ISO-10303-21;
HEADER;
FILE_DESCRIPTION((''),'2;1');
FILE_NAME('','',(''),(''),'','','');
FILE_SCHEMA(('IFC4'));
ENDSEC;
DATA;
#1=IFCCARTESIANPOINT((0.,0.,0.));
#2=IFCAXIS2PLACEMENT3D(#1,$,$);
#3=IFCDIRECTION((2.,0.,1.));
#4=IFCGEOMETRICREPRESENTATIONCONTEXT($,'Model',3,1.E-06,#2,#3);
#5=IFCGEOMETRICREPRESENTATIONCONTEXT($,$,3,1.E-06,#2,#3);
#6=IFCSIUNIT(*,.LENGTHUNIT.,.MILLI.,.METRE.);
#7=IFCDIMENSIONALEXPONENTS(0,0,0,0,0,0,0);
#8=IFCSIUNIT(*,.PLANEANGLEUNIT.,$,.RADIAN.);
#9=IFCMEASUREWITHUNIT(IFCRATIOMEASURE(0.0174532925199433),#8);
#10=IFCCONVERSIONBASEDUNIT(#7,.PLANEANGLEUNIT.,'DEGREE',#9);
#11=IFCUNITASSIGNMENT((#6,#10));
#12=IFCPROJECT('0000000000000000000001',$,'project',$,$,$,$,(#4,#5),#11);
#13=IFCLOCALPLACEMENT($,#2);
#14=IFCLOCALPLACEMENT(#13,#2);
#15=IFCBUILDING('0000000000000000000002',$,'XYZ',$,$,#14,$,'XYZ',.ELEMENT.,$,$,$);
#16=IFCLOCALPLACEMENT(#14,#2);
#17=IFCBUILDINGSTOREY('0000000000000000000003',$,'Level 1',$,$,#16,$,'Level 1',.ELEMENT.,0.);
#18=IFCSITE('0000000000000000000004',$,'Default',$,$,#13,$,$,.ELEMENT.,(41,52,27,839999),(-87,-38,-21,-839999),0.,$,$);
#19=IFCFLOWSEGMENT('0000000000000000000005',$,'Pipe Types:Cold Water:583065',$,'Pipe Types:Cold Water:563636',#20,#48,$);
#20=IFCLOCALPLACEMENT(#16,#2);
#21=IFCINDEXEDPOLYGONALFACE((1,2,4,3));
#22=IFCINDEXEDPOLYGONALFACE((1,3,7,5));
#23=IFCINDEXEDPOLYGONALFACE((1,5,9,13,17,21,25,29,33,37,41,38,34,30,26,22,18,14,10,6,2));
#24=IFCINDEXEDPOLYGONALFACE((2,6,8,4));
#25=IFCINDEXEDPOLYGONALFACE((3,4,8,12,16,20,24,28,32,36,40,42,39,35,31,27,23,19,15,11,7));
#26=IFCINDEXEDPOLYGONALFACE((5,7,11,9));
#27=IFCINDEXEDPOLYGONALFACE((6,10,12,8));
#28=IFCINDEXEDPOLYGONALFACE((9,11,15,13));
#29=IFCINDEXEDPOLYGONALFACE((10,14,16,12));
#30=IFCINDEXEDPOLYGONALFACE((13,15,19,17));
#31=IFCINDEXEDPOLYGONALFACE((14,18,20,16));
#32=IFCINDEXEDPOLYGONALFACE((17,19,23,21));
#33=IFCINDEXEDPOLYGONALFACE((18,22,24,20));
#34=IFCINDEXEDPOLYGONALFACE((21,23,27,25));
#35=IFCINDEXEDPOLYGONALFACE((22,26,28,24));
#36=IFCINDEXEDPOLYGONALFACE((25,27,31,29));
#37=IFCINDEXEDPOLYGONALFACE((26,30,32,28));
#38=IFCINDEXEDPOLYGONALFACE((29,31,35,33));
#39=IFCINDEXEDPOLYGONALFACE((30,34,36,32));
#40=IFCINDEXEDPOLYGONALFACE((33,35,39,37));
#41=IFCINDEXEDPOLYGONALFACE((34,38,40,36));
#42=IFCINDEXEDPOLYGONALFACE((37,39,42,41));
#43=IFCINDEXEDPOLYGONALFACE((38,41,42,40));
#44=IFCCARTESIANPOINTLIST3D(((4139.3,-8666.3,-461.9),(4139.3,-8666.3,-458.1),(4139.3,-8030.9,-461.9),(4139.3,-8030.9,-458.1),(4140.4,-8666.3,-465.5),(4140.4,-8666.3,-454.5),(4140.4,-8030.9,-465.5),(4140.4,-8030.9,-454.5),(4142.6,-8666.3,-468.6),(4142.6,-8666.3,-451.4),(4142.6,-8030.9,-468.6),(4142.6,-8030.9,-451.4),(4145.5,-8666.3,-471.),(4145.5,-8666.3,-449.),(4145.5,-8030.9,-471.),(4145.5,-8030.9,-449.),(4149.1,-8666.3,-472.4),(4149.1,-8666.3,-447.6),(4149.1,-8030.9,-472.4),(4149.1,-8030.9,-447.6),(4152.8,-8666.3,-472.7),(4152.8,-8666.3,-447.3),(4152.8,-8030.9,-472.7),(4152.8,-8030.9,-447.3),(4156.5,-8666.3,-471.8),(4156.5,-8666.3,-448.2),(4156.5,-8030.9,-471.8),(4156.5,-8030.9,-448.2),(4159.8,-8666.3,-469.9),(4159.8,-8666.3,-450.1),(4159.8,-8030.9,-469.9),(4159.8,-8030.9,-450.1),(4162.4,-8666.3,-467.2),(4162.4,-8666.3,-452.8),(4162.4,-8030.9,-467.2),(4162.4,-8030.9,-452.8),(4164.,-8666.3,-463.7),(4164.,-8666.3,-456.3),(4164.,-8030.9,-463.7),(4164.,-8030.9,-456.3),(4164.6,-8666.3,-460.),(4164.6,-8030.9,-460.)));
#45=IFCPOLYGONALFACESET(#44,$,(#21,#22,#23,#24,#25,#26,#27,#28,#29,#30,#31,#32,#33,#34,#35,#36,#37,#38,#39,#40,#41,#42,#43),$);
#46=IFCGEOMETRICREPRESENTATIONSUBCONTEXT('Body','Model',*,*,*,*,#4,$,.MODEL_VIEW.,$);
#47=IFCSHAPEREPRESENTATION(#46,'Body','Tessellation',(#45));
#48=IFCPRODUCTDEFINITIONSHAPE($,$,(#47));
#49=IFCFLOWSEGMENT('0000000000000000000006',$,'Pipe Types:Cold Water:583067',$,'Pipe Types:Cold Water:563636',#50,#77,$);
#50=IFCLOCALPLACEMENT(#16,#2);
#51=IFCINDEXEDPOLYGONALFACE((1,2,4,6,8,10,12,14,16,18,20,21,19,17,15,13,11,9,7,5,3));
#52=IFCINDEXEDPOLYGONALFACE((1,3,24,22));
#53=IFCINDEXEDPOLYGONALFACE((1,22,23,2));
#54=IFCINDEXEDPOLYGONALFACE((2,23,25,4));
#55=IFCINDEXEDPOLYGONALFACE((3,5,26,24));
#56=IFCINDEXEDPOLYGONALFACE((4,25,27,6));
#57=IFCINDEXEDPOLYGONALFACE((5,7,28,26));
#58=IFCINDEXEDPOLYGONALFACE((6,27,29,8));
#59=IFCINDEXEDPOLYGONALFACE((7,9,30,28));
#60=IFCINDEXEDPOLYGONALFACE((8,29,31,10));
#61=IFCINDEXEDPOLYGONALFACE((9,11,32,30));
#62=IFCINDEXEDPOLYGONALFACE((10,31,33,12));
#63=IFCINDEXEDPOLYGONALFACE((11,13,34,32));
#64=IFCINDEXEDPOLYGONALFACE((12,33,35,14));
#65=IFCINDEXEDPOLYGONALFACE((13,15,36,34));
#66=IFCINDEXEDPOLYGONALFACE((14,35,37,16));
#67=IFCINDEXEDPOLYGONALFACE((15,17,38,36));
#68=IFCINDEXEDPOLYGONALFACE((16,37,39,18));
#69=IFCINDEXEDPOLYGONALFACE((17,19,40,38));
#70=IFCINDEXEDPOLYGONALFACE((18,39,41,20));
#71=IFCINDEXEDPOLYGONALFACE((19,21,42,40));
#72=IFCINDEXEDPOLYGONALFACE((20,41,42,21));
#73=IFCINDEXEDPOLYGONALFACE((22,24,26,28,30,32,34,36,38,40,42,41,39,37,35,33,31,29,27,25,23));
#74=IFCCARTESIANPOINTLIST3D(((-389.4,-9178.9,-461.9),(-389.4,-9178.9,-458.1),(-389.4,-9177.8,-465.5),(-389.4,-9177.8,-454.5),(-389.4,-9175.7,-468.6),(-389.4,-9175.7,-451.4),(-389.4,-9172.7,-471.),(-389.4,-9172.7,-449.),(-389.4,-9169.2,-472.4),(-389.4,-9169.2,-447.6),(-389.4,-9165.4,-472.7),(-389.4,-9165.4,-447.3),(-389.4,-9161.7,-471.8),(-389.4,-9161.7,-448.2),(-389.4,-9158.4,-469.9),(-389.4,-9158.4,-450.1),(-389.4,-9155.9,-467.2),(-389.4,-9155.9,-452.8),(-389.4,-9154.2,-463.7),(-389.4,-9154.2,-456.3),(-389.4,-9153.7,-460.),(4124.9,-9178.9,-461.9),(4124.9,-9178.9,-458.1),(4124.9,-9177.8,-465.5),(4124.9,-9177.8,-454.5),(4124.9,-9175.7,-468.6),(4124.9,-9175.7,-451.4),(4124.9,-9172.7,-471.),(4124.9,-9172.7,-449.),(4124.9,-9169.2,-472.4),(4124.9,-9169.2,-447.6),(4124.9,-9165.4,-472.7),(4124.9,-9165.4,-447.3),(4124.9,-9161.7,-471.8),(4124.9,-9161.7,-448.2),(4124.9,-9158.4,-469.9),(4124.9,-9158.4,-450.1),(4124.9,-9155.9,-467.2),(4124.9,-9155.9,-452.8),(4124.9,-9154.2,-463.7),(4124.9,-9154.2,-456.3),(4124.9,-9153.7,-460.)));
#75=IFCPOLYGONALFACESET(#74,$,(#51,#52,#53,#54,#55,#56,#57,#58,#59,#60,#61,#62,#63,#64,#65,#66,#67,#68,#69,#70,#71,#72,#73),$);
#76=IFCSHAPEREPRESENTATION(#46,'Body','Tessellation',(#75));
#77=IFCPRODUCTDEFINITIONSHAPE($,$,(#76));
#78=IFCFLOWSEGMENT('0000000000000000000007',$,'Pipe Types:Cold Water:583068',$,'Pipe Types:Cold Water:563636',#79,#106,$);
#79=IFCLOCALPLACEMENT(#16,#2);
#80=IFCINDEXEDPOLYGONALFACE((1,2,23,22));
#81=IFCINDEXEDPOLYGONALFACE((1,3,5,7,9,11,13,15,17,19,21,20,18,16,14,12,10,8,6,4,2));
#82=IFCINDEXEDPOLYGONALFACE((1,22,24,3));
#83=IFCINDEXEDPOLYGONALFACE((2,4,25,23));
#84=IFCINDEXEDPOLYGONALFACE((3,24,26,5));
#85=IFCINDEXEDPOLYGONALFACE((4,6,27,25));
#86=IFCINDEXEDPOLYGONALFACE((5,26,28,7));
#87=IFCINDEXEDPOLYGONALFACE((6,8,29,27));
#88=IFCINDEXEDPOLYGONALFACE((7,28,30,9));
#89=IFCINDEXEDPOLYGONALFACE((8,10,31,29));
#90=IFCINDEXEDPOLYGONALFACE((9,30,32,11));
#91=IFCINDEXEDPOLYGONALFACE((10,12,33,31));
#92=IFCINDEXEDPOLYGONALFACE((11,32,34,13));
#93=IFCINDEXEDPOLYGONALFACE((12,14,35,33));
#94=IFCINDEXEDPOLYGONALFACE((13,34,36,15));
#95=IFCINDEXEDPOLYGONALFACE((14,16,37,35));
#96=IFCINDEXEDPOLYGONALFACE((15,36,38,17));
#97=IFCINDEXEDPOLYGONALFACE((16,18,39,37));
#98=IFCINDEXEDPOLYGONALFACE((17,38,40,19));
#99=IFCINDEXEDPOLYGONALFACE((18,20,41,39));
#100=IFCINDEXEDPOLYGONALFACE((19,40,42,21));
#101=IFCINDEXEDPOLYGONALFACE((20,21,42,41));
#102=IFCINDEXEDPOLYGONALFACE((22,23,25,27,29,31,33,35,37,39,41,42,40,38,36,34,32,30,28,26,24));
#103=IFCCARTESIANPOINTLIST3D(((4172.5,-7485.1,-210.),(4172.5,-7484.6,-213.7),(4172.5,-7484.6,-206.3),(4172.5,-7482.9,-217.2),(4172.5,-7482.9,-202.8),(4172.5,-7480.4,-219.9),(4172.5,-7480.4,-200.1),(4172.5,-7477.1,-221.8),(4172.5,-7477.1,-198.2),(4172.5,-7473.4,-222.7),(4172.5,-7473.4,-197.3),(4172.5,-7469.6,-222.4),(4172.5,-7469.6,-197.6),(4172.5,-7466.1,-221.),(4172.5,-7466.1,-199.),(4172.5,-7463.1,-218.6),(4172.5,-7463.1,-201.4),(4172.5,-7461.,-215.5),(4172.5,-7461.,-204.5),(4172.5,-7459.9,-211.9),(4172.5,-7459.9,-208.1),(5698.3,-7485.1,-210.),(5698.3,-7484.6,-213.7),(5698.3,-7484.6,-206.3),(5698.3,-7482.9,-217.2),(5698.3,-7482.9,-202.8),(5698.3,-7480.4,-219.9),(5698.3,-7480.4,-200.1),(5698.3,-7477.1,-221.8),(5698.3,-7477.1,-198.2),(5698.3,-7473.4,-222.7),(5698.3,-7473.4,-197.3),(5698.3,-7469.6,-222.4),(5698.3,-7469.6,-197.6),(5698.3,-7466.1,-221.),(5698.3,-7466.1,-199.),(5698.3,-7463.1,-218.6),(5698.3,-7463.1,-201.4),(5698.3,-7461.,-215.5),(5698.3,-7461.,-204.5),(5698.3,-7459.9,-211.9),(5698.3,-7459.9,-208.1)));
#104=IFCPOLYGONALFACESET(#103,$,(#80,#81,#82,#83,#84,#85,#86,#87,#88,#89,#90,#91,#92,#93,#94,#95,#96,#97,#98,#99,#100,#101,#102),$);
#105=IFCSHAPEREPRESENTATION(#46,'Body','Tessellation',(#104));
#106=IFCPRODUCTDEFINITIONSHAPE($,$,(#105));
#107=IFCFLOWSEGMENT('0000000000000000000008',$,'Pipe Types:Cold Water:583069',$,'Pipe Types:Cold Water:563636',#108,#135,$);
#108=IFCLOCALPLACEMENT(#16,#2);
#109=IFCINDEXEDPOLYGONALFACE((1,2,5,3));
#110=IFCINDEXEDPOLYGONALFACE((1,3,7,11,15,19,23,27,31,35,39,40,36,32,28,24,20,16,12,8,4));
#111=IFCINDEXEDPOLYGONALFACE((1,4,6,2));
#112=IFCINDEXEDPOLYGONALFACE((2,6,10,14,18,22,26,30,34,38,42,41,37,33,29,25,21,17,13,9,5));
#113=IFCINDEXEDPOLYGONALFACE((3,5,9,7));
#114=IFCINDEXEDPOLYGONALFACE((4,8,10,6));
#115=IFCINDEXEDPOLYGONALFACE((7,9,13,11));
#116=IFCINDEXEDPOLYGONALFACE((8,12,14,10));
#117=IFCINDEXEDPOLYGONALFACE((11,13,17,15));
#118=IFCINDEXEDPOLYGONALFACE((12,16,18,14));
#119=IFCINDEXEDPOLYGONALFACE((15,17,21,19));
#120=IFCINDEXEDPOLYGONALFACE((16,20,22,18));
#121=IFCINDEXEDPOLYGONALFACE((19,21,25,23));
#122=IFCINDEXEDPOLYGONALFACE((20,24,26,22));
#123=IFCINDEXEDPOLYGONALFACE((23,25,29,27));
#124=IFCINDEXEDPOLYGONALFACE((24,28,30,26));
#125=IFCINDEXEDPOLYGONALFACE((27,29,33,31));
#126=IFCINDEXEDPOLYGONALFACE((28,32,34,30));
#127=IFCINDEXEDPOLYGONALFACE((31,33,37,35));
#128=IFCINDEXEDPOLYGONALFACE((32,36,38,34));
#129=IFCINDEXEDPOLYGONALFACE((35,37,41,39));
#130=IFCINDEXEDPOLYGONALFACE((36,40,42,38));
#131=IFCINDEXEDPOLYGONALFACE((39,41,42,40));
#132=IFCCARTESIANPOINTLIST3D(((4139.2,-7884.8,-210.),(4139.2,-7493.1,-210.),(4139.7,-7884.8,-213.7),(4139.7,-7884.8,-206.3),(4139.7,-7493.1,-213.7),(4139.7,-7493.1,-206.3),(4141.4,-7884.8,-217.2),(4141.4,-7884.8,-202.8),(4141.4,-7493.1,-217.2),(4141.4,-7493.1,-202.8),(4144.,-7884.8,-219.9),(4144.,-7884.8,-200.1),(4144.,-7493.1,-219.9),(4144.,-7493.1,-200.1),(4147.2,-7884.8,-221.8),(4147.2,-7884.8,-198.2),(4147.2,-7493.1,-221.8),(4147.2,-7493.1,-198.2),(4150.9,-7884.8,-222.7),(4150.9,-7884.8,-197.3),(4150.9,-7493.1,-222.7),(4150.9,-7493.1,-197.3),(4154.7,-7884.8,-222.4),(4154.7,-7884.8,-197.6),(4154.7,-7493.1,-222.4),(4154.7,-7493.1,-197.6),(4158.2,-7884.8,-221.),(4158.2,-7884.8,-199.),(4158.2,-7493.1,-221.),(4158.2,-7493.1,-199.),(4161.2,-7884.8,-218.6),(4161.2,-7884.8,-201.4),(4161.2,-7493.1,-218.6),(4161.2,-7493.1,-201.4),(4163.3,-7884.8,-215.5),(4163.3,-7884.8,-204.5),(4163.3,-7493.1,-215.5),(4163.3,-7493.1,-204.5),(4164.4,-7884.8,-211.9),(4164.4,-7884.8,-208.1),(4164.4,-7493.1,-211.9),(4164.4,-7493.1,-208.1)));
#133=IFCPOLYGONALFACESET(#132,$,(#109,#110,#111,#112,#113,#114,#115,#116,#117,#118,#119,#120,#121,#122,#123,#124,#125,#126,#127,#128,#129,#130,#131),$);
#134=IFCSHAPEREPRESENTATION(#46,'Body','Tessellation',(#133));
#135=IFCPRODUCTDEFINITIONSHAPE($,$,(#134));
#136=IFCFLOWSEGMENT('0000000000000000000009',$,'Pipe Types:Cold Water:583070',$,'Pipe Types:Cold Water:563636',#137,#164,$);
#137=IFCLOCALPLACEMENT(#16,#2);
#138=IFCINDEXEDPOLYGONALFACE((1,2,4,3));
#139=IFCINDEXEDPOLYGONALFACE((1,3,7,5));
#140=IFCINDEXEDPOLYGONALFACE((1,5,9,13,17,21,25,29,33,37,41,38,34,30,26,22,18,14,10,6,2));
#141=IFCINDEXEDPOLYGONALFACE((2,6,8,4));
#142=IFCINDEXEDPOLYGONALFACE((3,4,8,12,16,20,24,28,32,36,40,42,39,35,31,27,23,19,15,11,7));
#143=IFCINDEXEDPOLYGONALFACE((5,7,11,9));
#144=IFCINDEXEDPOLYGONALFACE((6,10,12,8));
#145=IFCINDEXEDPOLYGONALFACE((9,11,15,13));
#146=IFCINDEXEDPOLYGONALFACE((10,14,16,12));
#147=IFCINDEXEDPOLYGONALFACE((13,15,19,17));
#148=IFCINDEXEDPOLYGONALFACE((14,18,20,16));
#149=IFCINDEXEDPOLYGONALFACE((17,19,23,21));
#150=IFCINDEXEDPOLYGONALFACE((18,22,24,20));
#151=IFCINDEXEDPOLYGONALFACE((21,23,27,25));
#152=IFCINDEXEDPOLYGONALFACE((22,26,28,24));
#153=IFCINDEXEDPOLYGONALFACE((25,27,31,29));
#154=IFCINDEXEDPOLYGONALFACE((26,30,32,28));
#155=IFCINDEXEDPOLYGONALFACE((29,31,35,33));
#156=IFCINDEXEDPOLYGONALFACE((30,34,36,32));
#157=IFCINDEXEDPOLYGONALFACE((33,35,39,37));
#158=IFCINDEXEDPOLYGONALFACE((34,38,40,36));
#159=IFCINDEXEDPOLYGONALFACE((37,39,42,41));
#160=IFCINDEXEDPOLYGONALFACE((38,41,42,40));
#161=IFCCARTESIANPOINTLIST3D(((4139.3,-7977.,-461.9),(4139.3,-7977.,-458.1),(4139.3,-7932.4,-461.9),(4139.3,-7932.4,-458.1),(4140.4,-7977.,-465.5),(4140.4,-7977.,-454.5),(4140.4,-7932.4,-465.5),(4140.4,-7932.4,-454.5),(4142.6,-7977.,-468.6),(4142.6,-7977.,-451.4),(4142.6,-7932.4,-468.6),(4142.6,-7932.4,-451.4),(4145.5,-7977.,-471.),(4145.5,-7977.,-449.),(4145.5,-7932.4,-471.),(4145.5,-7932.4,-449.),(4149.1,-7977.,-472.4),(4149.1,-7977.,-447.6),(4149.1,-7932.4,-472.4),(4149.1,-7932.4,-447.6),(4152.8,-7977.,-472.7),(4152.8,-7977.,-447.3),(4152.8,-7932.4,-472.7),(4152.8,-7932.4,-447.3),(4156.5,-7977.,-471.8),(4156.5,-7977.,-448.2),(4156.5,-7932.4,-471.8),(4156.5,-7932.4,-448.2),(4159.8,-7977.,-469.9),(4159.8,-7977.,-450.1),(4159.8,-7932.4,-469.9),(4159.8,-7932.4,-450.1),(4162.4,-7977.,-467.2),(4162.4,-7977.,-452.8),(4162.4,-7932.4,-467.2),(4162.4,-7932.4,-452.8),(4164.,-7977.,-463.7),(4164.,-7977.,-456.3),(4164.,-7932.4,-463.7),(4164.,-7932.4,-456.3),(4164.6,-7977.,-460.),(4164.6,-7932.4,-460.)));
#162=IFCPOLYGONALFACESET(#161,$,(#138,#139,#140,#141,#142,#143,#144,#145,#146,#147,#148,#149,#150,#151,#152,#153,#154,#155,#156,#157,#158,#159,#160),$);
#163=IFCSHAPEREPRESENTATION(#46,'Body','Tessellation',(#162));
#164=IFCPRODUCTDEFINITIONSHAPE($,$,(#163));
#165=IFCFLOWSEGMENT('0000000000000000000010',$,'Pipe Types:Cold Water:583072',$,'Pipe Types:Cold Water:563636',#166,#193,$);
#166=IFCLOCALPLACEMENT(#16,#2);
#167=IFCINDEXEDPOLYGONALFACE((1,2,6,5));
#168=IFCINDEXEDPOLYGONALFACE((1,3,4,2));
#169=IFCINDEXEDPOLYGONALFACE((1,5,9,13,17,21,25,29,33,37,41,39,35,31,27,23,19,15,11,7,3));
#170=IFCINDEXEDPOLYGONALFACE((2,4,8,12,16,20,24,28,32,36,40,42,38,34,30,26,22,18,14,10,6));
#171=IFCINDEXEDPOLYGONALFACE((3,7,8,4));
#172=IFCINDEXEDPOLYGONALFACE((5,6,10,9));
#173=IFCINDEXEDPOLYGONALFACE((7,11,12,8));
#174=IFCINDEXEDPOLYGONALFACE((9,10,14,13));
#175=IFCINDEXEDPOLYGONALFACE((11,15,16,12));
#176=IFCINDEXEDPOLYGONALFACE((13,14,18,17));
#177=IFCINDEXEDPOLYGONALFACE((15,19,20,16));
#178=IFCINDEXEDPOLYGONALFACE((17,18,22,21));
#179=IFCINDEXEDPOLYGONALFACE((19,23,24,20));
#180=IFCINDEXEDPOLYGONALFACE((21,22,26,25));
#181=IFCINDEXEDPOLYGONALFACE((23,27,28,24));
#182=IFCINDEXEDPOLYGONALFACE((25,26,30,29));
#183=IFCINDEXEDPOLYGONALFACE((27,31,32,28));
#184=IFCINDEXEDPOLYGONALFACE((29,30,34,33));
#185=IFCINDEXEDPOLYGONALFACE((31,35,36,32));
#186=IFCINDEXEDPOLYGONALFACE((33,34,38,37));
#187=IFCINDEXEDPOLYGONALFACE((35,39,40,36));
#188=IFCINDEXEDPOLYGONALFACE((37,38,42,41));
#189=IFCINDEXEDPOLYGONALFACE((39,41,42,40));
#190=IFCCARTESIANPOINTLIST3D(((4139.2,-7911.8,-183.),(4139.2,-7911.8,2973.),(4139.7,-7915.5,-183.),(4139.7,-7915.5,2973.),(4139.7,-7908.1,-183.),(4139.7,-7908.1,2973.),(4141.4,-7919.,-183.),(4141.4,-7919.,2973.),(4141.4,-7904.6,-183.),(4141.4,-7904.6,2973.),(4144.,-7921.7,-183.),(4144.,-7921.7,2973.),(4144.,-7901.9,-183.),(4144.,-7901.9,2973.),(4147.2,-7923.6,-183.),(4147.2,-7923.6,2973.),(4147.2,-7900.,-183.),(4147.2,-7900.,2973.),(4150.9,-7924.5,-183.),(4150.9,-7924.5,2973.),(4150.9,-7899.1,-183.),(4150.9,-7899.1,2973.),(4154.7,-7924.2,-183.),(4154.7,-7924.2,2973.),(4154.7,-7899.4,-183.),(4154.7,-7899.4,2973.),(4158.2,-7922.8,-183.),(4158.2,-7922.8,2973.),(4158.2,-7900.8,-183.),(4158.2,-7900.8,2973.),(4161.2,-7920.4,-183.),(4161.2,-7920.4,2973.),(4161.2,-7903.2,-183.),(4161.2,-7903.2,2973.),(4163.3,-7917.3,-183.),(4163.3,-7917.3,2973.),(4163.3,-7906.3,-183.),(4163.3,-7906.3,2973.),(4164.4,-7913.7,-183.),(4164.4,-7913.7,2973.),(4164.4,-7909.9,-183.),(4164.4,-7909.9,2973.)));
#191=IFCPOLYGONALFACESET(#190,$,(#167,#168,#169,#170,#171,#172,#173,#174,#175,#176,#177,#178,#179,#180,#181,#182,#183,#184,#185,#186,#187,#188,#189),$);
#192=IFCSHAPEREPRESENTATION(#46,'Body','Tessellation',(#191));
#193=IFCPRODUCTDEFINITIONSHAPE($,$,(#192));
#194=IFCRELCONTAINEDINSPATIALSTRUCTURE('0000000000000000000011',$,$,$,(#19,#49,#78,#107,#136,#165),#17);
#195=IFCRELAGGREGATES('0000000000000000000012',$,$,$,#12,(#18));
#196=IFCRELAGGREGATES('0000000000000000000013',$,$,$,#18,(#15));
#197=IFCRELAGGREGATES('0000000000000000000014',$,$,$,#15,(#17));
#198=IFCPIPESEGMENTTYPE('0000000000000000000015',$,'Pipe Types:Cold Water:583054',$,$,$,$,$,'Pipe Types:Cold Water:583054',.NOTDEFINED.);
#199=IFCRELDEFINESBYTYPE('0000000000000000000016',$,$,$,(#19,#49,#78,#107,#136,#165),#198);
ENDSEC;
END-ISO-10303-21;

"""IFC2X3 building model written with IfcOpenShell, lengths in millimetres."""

from ifc_helpers import new_model, entity, si_unit, converted_unit, direction, frame, frame_2d, origin, origin_2d_with_axis, place, context, subcontext, project, spatial, circle, extrude, type_object, element, save


model = new_model("IFC2X3")

# Units and contexts
model_context = context("Model", 3, precision=1e-06, world=origin(), true_north=direction((2.0, 0.0, 1.0)))
context_of_model = context(None, 3, precision=1e-06, world=origin(), true_north=direction((2.0, 0.0, 1.0)))
body_context = subcontext(model_context, "Body", "Model", "MODEL_VIEW")
ifc_project = project(units=[si_unit("LENGTHUNIT", "METRE", prefix="MILLI"), converted_unit("PLANEANGLEUNIT", "DEGREE", entity("IfcRatioMeasure", 0.0174532925199433), si_unit("PLANEANGLEUNIT", "RADIAN"), dimensions=[0, 0, 0, 0, 0, 0, 0])], contexts=[model_context, context_of_model])

# Site, building, storey
site_placement = place(None, origin())
site = spatial("IfcSite", under=ifc_project, at=site_placement, Name="Default", CompositionType="ELEMENT", RefLatitude=(41, 52, 27, 839999), RefLongitude=(-87, -38, -21, -839999), RefElevation=0.0)
building_placement = place(site_placement, origin())
building = spatial("IfcBuilding", under=site, at=building_placement, Name="XYZ", LongName="XYZ", CompositionType="ELEMENT")
storey_placement = place(building_placement, origin())
storey = spatial("IfcBuildingStorey", under=building, at=storey_placement, Name="Level 1", LongName="Level 1", CompositionType="ELEMENT", Elevation=0.0)

# Flow segments
pipe_segment_type_1 = type_object("IfcPipeSegmentType", Name="Pipe Types:Cold Water:583054", ElementType="Pipe Types:Cold Water:583054", PredefinedType="NOTDEFINED")
flow_segment_1_placement = place(storey_placement, origin())
element("IfcFlowSegment", 1, at=flow_segment_1_placement, inside=storey, type_object=pipe_segment_type_1, Name="Pipe Types:Cold Water:583065", ObjectType="Pipe Types:Cold Water:563636", context=body_context, shape_type="SweptSolid", body=[
    extrude(circle(Radius=12.7, at=origin_2d_with_axis()), frame((4151.9, -8666.3, -460.0), z_axis=(0.0, 1.0, 0.0), x_axis=(1.0, 0.0, 0.0)), (0.0, 0.0, 1.0), 635.4),
])
flow_segment_2_placement = place(storey_placement, origin())
element("IfcFlowSegment", 2, at=flow_segment_2_placement, inside=storey, type_object=pipe_segment_type_1, Name="Pipe Types:Cold Water:583067", ObjectType="Pipe Types:Cold Water:563636", context=body_context, shape_type="SweptSolid", body=[
    extrude(circle(Radius=12.7, at=frame_2d((0.0, 0.0), x_axis=(1.0, 0.0))), frame((-389.4, -9166.4, -460.0), z_axis=(1.0, 0.0, 0.0), x_axis=(0.0, 1.0, 0.0)), (0.0, 0.0, 1.0), 4514.3),
])
flow_segment_3_placement = place(storey_placement, origin())
element("IfcFlowSegment", 3, at=flow_segment_3_placement, inside=storey, type_object=pipe_segment_type_1, Name="Pipe Types:Cold Water:583068", ObjectType="Pipe Types:Cold Water:563636", context=body_context, shape_type="SweptSolid", body=[
    extrude(circle(Radius=12.7, at=origin_2d_with_axis()), frame((4172.5, -7472.4, -210.0), z_axis=(1.0, 0.0, 0.0), x_axis=(0.0, -1.0, 0.0)), (0.0, 0.0, 1.0), 1525.7),
])
flow_segment_4_placement = place(storey_placement, origin())
element("IfcFlowSegment", 4, at=flow_segment_4_placement, inside=storey, type_object=pipe_segment_type_1, Name="Pipe Types:Cold Water:583069", ObjectType="Pipe Types:Cold Water:563636", context=body_context, shape_type="SweptSolid", body=[
    extrude(circle(Radius=12.7, at=origin_2d_with_axis()), frame((4151.9, -7884.8, -210.0), z_axis=(0.0, 1.0, 0.0), x_axis=(-1.0, 0.0, 0.0)), (0.0, 0.0, 1.0), 391.7),
])
flow_segment_5_placement = place(storey_placement, origin())
element("IfcFlowSegment", 5, at=flow_segment_5_placement, inside=storey, type_object=pipe_segment_type_1, Name="Pipe Types:Cold Water:583070", ObjectType="Pipe Types:Cold Water:563636", context=body_context, shape_type="SweptSolid", body=[
    extrude(circle(Radius=12.7, at=frame_2d((0.0, 0.0), x_axis=(1.0, 0.0))), frame((4151.9, -7977.0, -460.0), z_axis=(0.0, 1.0, 0.0), x_axis=(1.0, 0.0, 0.0)), (0.0, 0.0, 1.0), 44.5),
])
flow_segment_6_placement = place(storey_placement, origin())
element("IfcFlowSegment", 6, at=flow_segment_6_placement, inside=storey, type_object=pipe_segment_type_1, Name="Pipe Types:Cold Water:583072", ObjectType="Pipe Types:Cold Water:563636", context=body_context, shape_type="SweptSolid", body=[
    extrude(circle(Radius=12.7, at=frame_2d((0.0, 0.0), x_axis=(1.0, 0.0))), frame((4151.9, -7911.8, -183.0), z_axis=(0.0, 0.0, 1.0), x_axis=(-1.0, 0.0, 0.0)), (0.0, 0.0, 1.0), 3156.0),
])

save(model, "model.ifc")
